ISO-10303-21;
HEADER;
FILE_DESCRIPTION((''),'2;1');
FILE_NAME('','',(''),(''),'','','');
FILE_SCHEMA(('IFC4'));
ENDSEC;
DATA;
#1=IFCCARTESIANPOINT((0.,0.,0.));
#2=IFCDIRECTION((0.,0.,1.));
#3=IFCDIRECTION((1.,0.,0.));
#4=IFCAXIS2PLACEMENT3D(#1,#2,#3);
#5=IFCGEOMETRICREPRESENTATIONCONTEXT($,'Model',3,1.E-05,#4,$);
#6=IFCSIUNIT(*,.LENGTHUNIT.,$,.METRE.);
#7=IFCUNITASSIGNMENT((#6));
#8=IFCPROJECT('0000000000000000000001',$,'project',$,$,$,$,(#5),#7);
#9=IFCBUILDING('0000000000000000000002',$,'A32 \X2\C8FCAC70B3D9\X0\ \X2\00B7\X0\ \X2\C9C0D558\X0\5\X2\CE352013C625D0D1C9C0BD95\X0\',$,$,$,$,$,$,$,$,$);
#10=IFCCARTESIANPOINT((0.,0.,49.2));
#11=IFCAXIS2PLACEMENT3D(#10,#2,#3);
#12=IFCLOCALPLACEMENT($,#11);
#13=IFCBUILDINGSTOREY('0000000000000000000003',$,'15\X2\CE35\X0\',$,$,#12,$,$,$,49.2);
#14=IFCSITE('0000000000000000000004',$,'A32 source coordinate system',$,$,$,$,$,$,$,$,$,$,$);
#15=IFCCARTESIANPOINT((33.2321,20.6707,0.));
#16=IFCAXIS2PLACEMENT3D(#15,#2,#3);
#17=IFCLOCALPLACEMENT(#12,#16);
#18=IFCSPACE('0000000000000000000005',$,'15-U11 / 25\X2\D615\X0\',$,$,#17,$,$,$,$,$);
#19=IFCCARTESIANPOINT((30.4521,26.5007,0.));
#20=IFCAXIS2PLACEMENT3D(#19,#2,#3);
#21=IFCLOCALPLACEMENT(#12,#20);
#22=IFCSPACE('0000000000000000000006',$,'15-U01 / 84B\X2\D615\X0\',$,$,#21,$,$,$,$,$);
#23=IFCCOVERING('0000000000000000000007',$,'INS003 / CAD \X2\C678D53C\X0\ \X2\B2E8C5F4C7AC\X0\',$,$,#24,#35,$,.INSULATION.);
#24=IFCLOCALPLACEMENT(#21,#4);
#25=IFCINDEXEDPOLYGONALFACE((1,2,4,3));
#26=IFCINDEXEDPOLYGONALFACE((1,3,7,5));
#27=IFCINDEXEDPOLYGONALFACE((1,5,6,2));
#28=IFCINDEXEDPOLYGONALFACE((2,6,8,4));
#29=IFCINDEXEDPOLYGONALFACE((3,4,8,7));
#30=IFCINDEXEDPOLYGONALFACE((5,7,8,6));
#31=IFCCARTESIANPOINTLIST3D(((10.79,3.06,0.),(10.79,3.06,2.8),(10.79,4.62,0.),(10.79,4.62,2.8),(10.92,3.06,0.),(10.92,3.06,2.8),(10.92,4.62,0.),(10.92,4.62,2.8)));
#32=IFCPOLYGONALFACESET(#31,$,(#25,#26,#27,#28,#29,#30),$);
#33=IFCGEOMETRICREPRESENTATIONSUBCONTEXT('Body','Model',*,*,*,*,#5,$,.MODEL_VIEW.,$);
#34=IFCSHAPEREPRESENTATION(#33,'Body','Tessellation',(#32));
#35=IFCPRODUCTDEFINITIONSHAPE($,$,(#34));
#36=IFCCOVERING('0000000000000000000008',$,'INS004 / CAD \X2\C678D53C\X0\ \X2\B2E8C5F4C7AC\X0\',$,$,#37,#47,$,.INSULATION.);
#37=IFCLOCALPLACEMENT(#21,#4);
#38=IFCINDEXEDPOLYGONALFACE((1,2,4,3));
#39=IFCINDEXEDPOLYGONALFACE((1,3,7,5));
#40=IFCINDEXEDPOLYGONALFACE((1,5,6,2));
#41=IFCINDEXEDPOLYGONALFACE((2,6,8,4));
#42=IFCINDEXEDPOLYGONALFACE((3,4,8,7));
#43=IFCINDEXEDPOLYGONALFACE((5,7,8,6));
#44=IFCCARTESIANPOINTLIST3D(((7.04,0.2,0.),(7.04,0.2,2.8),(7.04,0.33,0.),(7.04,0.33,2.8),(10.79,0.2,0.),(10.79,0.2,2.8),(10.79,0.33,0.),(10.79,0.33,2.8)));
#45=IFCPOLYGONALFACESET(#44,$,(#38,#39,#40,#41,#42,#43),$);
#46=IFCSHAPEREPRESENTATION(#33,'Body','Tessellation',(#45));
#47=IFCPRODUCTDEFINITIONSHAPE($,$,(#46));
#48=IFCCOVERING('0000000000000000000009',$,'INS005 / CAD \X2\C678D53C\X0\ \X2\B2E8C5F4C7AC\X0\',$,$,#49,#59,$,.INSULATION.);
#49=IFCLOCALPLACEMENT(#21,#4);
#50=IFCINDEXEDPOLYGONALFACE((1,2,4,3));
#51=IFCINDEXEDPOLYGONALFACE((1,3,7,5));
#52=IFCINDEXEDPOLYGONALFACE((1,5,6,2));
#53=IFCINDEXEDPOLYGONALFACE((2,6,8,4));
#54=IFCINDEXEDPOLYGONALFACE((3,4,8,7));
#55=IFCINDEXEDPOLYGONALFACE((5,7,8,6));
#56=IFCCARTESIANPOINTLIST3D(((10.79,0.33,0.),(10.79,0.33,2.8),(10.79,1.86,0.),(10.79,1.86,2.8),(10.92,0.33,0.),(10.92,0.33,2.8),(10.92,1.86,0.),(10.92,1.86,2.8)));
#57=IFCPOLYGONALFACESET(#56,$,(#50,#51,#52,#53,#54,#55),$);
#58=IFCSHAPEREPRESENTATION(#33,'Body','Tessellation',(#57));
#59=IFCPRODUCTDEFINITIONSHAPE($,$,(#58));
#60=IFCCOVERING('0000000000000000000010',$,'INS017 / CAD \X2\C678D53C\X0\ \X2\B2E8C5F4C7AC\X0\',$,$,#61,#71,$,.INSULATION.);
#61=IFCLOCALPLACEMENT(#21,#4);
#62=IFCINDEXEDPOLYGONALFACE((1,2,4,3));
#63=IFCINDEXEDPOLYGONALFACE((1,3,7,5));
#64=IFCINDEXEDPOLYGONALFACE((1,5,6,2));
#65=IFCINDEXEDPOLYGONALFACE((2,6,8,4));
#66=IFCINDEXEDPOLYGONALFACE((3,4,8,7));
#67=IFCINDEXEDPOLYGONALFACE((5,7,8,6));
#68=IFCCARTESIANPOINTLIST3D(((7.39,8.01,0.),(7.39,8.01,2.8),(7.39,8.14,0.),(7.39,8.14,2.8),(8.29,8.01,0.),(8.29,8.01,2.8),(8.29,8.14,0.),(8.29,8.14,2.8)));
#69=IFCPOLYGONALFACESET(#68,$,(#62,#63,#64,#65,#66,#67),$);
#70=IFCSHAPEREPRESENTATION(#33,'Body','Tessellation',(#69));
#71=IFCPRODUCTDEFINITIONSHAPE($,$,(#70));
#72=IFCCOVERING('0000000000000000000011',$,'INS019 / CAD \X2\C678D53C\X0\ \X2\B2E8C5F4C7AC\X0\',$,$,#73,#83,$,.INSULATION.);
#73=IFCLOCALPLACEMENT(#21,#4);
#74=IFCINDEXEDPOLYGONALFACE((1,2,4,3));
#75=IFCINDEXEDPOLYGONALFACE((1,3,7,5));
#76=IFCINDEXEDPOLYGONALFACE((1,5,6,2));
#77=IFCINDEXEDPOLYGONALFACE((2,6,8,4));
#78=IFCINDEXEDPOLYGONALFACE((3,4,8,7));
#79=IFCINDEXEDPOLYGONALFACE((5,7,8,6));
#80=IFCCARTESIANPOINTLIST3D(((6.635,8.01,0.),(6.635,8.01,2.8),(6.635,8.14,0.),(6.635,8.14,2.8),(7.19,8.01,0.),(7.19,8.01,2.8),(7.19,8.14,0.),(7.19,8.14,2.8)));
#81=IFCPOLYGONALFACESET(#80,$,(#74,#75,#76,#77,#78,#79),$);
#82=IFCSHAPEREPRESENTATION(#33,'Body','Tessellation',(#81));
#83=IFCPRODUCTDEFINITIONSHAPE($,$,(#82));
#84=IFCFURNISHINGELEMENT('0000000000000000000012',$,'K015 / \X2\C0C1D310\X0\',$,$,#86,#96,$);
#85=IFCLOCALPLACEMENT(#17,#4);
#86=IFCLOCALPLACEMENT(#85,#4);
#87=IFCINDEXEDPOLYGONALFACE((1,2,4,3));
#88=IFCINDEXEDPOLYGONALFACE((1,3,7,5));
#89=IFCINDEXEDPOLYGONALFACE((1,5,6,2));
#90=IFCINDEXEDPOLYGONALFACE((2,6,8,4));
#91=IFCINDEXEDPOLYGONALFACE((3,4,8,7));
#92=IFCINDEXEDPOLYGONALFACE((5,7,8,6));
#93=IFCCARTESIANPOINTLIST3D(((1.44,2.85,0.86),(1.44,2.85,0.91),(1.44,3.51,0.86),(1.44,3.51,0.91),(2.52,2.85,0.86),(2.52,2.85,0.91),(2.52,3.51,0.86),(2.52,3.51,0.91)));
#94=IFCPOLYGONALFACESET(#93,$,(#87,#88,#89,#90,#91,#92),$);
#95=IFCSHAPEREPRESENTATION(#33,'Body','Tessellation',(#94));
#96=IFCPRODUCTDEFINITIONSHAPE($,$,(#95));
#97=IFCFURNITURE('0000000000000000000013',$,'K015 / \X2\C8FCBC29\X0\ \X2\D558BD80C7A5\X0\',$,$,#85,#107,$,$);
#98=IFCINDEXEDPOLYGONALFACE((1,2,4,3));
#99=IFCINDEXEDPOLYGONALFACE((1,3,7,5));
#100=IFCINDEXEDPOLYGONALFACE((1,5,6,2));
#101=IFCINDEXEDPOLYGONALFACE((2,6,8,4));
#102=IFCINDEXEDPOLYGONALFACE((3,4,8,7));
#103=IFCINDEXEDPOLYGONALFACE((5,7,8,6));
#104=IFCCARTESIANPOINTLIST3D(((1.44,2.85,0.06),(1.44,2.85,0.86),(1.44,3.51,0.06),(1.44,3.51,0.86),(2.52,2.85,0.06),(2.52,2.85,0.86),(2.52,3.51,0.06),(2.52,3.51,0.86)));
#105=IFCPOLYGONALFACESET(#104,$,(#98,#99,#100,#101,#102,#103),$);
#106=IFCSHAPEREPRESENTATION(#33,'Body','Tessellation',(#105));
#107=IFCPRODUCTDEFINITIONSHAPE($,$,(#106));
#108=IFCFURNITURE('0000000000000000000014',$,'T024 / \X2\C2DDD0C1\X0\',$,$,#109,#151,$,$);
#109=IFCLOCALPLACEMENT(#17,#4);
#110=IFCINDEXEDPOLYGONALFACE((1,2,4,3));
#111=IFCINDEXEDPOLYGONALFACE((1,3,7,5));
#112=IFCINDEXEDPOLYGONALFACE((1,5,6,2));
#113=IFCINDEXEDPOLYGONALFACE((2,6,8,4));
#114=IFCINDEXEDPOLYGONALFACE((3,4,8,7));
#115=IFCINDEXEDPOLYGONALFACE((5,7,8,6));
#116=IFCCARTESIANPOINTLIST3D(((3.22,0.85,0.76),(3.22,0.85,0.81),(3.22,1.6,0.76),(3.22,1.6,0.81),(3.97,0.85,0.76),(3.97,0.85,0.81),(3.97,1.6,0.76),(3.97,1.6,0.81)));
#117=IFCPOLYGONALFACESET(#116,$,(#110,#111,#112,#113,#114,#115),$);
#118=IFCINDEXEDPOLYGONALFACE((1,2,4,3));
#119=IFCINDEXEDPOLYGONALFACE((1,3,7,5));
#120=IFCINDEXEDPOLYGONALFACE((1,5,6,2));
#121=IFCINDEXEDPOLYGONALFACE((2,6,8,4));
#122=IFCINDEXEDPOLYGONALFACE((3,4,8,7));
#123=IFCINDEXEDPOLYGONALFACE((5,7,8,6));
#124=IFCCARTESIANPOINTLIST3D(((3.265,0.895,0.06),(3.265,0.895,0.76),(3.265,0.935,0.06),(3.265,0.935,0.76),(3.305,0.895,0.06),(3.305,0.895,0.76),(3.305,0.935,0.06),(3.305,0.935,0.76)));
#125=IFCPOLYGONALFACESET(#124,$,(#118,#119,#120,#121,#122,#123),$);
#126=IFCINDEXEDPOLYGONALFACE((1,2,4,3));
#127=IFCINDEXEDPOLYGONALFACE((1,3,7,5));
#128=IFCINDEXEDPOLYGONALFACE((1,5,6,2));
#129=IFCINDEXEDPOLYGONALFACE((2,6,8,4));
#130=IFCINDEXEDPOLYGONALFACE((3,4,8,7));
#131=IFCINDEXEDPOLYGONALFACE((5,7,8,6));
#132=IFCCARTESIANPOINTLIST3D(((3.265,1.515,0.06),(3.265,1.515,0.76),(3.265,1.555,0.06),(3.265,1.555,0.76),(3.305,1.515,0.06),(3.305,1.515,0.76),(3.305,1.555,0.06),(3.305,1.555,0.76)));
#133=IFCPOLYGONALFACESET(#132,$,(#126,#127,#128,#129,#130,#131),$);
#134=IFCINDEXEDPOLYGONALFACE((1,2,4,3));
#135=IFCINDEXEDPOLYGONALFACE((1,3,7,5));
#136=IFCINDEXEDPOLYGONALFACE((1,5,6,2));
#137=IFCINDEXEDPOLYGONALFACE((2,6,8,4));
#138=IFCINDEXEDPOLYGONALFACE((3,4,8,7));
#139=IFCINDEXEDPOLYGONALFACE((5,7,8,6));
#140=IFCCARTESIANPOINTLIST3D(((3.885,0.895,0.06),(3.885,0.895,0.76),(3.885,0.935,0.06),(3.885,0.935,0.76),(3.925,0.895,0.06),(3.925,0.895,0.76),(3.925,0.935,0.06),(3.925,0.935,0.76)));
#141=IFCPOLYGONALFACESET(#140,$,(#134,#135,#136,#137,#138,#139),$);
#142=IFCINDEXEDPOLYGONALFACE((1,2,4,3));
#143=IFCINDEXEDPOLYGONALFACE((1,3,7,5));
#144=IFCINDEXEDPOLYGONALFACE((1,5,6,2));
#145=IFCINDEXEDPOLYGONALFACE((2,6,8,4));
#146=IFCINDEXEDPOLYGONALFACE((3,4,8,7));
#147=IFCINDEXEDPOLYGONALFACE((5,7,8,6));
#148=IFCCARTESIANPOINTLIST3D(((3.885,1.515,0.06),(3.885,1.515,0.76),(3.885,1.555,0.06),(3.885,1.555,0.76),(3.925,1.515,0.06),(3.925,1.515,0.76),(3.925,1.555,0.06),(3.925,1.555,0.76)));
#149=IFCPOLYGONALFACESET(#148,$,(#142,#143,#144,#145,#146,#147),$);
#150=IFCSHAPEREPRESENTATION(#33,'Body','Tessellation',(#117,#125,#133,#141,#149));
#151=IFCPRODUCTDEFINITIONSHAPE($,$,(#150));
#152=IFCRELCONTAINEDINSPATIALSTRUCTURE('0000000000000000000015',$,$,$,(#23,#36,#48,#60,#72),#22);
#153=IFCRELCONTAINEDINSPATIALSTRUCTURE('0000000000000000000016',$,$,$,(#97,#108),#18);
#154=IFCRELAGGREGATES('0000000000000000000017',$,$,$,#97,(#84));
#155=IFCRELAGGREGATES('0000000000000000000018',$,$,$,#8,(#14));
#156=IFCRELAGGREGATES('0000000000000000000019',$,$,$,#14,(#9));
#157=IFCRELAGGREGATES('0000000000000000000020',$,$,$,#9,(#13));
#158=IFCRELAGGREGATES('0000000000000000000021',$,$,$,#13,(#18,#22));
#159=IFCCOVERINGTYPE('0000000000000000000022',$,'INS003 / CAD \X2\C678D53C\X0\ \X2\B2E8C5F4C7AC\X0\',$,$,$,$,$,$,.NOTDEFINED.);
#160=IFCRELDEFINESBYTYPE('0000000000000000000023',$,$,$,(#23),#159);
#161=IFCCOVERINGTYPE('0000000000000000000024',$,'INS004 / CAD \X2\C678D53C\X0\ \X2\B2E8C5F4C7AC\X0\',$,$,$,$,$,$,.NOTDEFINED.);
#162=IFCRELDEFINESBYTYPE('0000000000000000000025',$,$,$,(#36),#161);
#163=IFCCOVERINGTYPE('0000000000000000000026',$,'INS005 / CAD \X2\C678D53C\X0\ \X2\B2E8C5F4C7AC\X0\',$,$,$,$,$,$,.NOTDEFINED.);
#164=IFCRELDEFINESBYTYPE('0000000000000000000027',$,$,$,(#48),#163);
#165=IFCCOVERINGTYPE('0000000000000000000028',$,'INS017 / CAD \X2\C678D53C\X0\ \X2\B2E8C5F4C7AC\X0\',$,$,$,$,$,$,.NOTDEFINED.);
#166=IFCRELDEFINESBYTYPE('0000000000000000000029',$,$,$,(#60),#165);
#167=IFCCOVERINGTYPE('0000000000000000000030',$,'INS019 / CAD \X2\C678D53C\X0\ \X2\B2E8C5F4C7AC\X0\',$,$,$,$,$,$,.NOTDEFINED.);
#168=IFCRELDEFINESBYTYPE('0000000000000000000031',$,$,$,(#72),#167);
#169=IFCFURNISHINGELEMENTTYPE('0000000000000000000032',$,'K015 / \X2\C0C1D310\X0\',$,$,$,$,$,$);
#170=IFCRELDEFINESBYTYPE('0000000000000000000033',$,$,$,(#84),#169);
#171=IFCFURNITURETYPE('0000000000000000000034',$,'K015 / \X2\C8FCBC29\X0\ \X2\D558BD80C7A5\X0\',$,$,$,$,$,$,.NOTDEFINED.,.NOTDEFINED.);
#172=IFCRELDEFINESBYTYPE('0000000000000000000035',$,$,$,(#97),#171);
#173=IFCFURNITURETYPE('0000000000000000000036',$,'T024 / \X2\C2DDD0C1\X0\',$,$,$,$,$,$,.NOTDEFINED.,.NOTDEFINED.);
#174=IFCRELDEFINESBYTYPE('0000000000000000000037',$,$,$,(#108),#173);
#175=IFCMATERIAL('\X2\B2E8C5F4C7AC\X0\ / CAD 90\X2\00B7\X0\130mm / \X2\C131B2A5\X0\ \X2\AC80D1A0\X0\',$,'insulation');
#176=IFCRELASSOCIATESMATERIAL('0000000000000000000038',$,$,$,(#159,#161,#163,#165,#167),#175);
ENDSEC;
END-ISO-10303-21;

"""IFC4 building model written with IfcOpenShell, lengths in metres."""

from ifc_helpers import new_model, si_unit, frame, origin, origin_with_axes, place, context, subcontext, project, spatial, polyline, outline, extrude, source, transform, mapped, material, type_object, type_shapes, element, aggregate, save


model = new_model("IFC4")

# Units and contexts
model_context = context("Model", 3, precision=1e-05, world=origin_with_axes())
body_context = subcontext(model_context, "Body", "Model", "MODEL_VIEW")
ifc_project = project(units=[si_unit("LENGTHUNIT", "METRE")], contexts=[model_context])

# Site, building, storey, space
site = spatial("IfcSite", under=ifc_project, Name="A32 source coordinate system")
building = spatial("IfcBuilding", under=site, Name="A32 주거동 · 지하5층–옥탑지붕")
storey_placement = place(None, frame((0.0, 0.0, 49.2), z_axis=(0.0, 0.0, 1.0), x_axis=(1.0, 0.0, 0.0)))
storey = spatial("IfcBuildingStorey", under=building, at=storey_placement, Name="15층", Elevation=49.2)
space_1_placement = place(storey_placement, frame((33.2321, 20.6707, 0.0), z_axis=(0.0, 0.0, 1.0), x_axis=(1.0, 0.0, 0.0)))
space_1 = spatial("IfcSpace", under=storey, at=space_1_placement, Name="15-U11 / 25형")

# Shared definitions
space_2_placement = place(storey_placement, frame((30.4521, 26.5007, 0.0), z_axis=(0.0, 0.0, 1.0), x_axis=(1.0, 0.0, 0.0)))
space_2 = spatial("IfcSpace", under=storey, at=space_2_placement, Name="15-U01 / 84B형")

# Coverings
ifc_material = material(Name="단열재 / CAD 90·130mm / 성능 검토", Category="insulation")
covering_type_1 = type_object("IfcCoveringType", Name="INS003 / CAD 외피 단열재", PredefinedType="NOTDEFINED", material=ifc_material)
shared_shape_1 = source(origin(), body_context, "Body", "SweptSolid", [
    extrude(outline(polyline([(10.79, 3.06), (10.79, 4.62), (10.92, 4.62), (10.92, 3.06), (10.79, 3.06)])), origin(), (0.0, 0.0, 1.0), 2.8),
])
type_shapes(covering_type_1, [shared_shape_1])
covering_1_placement = place(space_2_placement, origin_with_axes())
element("IfcCovering", 1, at=covering_1_placement, inside=space_2, type_object=covering_type_1, Name="INS003 / CAD 외피 단열재", PredefinedType="INSULATION", context=body_context, shape_type="MappedRepresentation", body=[
    mapped(shared_shape_1, transform((0.0, 0.0, 0.0), scale=1.0)),
])
covering_type_2 = type_object("IfcCoveringType", Name="INS004 / CAD 외피 단열재", PredefinedType="NOTDEFINED", material=ifc_material)
shared_shape_2 = source(origin(), body_context, "Body", "SweptSolid", [
    extrude(outline(polyline([(7.04, 0.33), (10.79, 0.33), (10.79, 0.2), (7.04, 0.2), (7.04, 0.33)])), origin(), (0.0, 0.0, 1.0), 2.8),
])
type_shapes(covering_type_2, [shared_shape_2])
covering_2_placement = place(space_2_placement, origin_with_axes())
element("IfcCovering", 2, at=covering_2_placement, inside=space_2, type_object=covering_type_2, Name="INS004 / CAD 외피 단열재", PredefinedType="INSULATION", context=body_context, shape_type="MappedRepresentation", body=[
    mapped(shared_shape_2, transform((0.0, 0.0, 0.0), scale=1.0)),
])
covering_type_3 = type_object("IfcCoveringType", Name="INS005 / CAD 외피 단열재", PredefinedType="NOTDEFINED", material=ifc_material)
shared_shape_3 = source(origin(), body_context, "Body", "SweptSolid", [
    extrude(outline(polyline([(10.79, 0.33), (10.79, 1.86), (10.92, 1.86), (10.92, 0.33), (10.79, 0.33)])), origin(), (0.0, 0.0, 1.0), 2.8),
])
type_shapes(covering_type_3, [shared_shape_3])
covering_3_placement = place(space_2_placement, origin_with_axes())
element("IfcCovering", 3, at=covering_3_placement, inside=space_2, type_object=covering_type_3, Name="INS005 / CAD 외피 단열재", PredefinedType="INSULATION", context=body_context, shape_type="MappedRepresentation", body=[
    mapped(shared_shape_3, transform((0.0, 0.0, 0.0), scale=1.0)),
])
covering_type_4 = type_object("IfcCoveringType", Name="INS017 / CAD 외피 단열재", PredefinedType="NOTDEFINED", material=ifc_material)
shared_shape_4 = source(origin(), body_context, "Body", "SweptSolid", [
    extrude(outline(polyline([(8.29, 8.01), (7.39, 8.01), (7.39, 8.14), (8.29, 8.14), (8.29, 8.01)])), origin(), (0.0, 0.0, 1.0), 2.8),
])
type_shapes(covering_type_4, [shared_shape_4])
covering_4_placement = place(space_2_placement, origin_with_axes())
element("IfcCovering", 4, at=covering_4_placement, inside=space_2, type_object=covering_type_4, Name="INS017 / CAD 외피 단열재", PredefinedType="INSULATION", context=body_context, shape_type="MappedRepresentation", body=[
    mapped(shared_shape_4, transform((0.0, 0.0, 0.0), scale=1.0)),
])
covering_type_5 = type_object("IfcCoveringType", Name="INS019 / CAD 외피 단열재", PredefinedType="NOTDEFINED", material=ifc_material)
shared_shape_5 = source(origin(), body_context, "Body", "SweptSolid", [
    extrude(outline(polyline([(6.635, 8.01), (6.635, 8.14), (7.19, 8.14), (7.19, 8.01), (6.635, 8.01)])), origin(), (0.0, 0.0, 1.0), 2.8),
])
type_shapes(covering_type_5, [shared_shape_5])
covering_5_placement = place(space_2_placement, origin_with_axes())
element("IfcCovering", 5, at=covering_5_placement, inside=space_2, type_object=covering_type_5, Name="INS019 / CAD 외피 단열재", PredefinedType="INSULATION", context=body_context, shape_type="MappedRepresentation", body=[
    mapped(shared_shape_5, transform((0.0, 0.0, 0.0), scale=1.0)),
])

# Furnishing element
furnishing_element_type_1 = type_object("IfcFurnishingElementType", Name="K015 / 상판")
shared_shape_6 = source(origin(), body_context, "Body", "SweptSolid", [
    extrude(outline(polyline([(2.52, 2.85), (1.44, 2.85), (1.44, 3.51), (2.52, 3.51), (2.52, 2.85)])), frame((0.0, 0.0, 0.86)), (0.0, 0.0, 1.0), 0.05),
])
type_shapes(furnishing_element_type_1, [shared_shape_6])
furniture_1_placement = place(space_1_placement, origin_with_axes())
furnishing_1_placement = place(furniture_1_placement, origin_with_axes())
furnishing_1 = element("IfcFurnishingElement", 6, at=furnishing_1_placement, type_object=furnishing_element_type_1, Name="K015 / 상판", context=body_context, shape_type="MappedRepresentation", body=[
    mapped(shared_shape_6, transform((0.0, 0.0, 0.0), scale=1.0)),
])

# Furniture
furniture_type_1 = type_object("IfcFurnitureType", Name="K015 / 주방 하부장", AssemblyPlace="NOTDEFINED", PredefinedType="NOTDEFINED")
shared_shape_7 = source(origin(), body_context, "Body", "SweptSolid", [
    extrude(outline(polyline([(2.52, 3.51), (2.52, 2.85), (1.44, 2.85), (1.44, 3.51), (2.52, 3.51)])), frame((0.0, 0.0, 0.06)), (0.0, 0.0, 1.0), 0.8),
])
type_shapes(furniture_type_1, [shared_shape_7])
furniture_1 = element("IfcFurniture", 7, at=furniture_1_placement, inside=space_1, type_object=furniture_type_1, Name="K015 / 주방 하부장", context=body_context, shape_type="MappedRepresentation", body=[
    mapped(shared_shape_7, transform((0.0, 0.0, 0.0), scale=1.0)),
])
aggregate(furniture_1, [furnishing_1])
furniture_type_2 = type_object("IfcFurnitureType", Name="T024 / 식탁", AssemblyPlace="NOTDEFINED", PredefinedType="NOTDEFINED")
shared_shape_8 = source(origin(), body_context, "Body", "SweptSolid", [
    extrude(outline(polyline([(3.22, 0.85), (3.22, 1.6), (3.97, 1.6), (3.97, 0.85), (3.22, 0.85)])), frame((0.0, 0.0, 0.76)), (0.0, 0.0, 1.0), 0.05),
    extrude(outline(polyline([(3.265, 0.895), (3.265, 0.935), (3.305, 0.935), (3.305, 0.895), (3.265, 0.895)])), frame((0.0, 0.0, 0.06)), (0.0, 0.0, 1.0), 0.7),
    extrude(outline(polyline([(3.265, 1.515), (3.265, 1.555), (3.305, 1.555), (3.305, 1.515), (3.265, 1.515)])), frame((0.0, 0.0, 0.06)), (0.0, 0.0, 1.0), 0.7),
    extrude(outline(polyline([(3.885, 0.895), (3.885, 0.935), (3.925, 0.935), (3.925, 0.895), (3.885, 0.895)])), frame((0.0, 0.0, 0.06)), (0.0, 0.0, 1.0), 0.7),
    extrude(outline(polyline([(3.885, 1.515), (3.885, 1.555), (3.925, 1.555), (3.925, 1.515), (3.885, 1.515)])), frame((0.0, 0.0, 0.06)), (0.0, 0.0, 1.0), 0.7),
])
type_shapes(furniture_type_2, [shared_shape_8])
furniture_2_placement = place(space_1_placement, origin_with_axes())
element("IfcFurniture", 8, at=furniture_2_placement, inside=space_1, type_object=furniture_type_2, Name="T024 / 식탁", context=body_context, shape_type="MappedRepresentation", body=[
    mapped(shared_shape_8, transform((0.0, 0.0, 0.0), scale=1.0)),
])

save(model, "model.ifc")
